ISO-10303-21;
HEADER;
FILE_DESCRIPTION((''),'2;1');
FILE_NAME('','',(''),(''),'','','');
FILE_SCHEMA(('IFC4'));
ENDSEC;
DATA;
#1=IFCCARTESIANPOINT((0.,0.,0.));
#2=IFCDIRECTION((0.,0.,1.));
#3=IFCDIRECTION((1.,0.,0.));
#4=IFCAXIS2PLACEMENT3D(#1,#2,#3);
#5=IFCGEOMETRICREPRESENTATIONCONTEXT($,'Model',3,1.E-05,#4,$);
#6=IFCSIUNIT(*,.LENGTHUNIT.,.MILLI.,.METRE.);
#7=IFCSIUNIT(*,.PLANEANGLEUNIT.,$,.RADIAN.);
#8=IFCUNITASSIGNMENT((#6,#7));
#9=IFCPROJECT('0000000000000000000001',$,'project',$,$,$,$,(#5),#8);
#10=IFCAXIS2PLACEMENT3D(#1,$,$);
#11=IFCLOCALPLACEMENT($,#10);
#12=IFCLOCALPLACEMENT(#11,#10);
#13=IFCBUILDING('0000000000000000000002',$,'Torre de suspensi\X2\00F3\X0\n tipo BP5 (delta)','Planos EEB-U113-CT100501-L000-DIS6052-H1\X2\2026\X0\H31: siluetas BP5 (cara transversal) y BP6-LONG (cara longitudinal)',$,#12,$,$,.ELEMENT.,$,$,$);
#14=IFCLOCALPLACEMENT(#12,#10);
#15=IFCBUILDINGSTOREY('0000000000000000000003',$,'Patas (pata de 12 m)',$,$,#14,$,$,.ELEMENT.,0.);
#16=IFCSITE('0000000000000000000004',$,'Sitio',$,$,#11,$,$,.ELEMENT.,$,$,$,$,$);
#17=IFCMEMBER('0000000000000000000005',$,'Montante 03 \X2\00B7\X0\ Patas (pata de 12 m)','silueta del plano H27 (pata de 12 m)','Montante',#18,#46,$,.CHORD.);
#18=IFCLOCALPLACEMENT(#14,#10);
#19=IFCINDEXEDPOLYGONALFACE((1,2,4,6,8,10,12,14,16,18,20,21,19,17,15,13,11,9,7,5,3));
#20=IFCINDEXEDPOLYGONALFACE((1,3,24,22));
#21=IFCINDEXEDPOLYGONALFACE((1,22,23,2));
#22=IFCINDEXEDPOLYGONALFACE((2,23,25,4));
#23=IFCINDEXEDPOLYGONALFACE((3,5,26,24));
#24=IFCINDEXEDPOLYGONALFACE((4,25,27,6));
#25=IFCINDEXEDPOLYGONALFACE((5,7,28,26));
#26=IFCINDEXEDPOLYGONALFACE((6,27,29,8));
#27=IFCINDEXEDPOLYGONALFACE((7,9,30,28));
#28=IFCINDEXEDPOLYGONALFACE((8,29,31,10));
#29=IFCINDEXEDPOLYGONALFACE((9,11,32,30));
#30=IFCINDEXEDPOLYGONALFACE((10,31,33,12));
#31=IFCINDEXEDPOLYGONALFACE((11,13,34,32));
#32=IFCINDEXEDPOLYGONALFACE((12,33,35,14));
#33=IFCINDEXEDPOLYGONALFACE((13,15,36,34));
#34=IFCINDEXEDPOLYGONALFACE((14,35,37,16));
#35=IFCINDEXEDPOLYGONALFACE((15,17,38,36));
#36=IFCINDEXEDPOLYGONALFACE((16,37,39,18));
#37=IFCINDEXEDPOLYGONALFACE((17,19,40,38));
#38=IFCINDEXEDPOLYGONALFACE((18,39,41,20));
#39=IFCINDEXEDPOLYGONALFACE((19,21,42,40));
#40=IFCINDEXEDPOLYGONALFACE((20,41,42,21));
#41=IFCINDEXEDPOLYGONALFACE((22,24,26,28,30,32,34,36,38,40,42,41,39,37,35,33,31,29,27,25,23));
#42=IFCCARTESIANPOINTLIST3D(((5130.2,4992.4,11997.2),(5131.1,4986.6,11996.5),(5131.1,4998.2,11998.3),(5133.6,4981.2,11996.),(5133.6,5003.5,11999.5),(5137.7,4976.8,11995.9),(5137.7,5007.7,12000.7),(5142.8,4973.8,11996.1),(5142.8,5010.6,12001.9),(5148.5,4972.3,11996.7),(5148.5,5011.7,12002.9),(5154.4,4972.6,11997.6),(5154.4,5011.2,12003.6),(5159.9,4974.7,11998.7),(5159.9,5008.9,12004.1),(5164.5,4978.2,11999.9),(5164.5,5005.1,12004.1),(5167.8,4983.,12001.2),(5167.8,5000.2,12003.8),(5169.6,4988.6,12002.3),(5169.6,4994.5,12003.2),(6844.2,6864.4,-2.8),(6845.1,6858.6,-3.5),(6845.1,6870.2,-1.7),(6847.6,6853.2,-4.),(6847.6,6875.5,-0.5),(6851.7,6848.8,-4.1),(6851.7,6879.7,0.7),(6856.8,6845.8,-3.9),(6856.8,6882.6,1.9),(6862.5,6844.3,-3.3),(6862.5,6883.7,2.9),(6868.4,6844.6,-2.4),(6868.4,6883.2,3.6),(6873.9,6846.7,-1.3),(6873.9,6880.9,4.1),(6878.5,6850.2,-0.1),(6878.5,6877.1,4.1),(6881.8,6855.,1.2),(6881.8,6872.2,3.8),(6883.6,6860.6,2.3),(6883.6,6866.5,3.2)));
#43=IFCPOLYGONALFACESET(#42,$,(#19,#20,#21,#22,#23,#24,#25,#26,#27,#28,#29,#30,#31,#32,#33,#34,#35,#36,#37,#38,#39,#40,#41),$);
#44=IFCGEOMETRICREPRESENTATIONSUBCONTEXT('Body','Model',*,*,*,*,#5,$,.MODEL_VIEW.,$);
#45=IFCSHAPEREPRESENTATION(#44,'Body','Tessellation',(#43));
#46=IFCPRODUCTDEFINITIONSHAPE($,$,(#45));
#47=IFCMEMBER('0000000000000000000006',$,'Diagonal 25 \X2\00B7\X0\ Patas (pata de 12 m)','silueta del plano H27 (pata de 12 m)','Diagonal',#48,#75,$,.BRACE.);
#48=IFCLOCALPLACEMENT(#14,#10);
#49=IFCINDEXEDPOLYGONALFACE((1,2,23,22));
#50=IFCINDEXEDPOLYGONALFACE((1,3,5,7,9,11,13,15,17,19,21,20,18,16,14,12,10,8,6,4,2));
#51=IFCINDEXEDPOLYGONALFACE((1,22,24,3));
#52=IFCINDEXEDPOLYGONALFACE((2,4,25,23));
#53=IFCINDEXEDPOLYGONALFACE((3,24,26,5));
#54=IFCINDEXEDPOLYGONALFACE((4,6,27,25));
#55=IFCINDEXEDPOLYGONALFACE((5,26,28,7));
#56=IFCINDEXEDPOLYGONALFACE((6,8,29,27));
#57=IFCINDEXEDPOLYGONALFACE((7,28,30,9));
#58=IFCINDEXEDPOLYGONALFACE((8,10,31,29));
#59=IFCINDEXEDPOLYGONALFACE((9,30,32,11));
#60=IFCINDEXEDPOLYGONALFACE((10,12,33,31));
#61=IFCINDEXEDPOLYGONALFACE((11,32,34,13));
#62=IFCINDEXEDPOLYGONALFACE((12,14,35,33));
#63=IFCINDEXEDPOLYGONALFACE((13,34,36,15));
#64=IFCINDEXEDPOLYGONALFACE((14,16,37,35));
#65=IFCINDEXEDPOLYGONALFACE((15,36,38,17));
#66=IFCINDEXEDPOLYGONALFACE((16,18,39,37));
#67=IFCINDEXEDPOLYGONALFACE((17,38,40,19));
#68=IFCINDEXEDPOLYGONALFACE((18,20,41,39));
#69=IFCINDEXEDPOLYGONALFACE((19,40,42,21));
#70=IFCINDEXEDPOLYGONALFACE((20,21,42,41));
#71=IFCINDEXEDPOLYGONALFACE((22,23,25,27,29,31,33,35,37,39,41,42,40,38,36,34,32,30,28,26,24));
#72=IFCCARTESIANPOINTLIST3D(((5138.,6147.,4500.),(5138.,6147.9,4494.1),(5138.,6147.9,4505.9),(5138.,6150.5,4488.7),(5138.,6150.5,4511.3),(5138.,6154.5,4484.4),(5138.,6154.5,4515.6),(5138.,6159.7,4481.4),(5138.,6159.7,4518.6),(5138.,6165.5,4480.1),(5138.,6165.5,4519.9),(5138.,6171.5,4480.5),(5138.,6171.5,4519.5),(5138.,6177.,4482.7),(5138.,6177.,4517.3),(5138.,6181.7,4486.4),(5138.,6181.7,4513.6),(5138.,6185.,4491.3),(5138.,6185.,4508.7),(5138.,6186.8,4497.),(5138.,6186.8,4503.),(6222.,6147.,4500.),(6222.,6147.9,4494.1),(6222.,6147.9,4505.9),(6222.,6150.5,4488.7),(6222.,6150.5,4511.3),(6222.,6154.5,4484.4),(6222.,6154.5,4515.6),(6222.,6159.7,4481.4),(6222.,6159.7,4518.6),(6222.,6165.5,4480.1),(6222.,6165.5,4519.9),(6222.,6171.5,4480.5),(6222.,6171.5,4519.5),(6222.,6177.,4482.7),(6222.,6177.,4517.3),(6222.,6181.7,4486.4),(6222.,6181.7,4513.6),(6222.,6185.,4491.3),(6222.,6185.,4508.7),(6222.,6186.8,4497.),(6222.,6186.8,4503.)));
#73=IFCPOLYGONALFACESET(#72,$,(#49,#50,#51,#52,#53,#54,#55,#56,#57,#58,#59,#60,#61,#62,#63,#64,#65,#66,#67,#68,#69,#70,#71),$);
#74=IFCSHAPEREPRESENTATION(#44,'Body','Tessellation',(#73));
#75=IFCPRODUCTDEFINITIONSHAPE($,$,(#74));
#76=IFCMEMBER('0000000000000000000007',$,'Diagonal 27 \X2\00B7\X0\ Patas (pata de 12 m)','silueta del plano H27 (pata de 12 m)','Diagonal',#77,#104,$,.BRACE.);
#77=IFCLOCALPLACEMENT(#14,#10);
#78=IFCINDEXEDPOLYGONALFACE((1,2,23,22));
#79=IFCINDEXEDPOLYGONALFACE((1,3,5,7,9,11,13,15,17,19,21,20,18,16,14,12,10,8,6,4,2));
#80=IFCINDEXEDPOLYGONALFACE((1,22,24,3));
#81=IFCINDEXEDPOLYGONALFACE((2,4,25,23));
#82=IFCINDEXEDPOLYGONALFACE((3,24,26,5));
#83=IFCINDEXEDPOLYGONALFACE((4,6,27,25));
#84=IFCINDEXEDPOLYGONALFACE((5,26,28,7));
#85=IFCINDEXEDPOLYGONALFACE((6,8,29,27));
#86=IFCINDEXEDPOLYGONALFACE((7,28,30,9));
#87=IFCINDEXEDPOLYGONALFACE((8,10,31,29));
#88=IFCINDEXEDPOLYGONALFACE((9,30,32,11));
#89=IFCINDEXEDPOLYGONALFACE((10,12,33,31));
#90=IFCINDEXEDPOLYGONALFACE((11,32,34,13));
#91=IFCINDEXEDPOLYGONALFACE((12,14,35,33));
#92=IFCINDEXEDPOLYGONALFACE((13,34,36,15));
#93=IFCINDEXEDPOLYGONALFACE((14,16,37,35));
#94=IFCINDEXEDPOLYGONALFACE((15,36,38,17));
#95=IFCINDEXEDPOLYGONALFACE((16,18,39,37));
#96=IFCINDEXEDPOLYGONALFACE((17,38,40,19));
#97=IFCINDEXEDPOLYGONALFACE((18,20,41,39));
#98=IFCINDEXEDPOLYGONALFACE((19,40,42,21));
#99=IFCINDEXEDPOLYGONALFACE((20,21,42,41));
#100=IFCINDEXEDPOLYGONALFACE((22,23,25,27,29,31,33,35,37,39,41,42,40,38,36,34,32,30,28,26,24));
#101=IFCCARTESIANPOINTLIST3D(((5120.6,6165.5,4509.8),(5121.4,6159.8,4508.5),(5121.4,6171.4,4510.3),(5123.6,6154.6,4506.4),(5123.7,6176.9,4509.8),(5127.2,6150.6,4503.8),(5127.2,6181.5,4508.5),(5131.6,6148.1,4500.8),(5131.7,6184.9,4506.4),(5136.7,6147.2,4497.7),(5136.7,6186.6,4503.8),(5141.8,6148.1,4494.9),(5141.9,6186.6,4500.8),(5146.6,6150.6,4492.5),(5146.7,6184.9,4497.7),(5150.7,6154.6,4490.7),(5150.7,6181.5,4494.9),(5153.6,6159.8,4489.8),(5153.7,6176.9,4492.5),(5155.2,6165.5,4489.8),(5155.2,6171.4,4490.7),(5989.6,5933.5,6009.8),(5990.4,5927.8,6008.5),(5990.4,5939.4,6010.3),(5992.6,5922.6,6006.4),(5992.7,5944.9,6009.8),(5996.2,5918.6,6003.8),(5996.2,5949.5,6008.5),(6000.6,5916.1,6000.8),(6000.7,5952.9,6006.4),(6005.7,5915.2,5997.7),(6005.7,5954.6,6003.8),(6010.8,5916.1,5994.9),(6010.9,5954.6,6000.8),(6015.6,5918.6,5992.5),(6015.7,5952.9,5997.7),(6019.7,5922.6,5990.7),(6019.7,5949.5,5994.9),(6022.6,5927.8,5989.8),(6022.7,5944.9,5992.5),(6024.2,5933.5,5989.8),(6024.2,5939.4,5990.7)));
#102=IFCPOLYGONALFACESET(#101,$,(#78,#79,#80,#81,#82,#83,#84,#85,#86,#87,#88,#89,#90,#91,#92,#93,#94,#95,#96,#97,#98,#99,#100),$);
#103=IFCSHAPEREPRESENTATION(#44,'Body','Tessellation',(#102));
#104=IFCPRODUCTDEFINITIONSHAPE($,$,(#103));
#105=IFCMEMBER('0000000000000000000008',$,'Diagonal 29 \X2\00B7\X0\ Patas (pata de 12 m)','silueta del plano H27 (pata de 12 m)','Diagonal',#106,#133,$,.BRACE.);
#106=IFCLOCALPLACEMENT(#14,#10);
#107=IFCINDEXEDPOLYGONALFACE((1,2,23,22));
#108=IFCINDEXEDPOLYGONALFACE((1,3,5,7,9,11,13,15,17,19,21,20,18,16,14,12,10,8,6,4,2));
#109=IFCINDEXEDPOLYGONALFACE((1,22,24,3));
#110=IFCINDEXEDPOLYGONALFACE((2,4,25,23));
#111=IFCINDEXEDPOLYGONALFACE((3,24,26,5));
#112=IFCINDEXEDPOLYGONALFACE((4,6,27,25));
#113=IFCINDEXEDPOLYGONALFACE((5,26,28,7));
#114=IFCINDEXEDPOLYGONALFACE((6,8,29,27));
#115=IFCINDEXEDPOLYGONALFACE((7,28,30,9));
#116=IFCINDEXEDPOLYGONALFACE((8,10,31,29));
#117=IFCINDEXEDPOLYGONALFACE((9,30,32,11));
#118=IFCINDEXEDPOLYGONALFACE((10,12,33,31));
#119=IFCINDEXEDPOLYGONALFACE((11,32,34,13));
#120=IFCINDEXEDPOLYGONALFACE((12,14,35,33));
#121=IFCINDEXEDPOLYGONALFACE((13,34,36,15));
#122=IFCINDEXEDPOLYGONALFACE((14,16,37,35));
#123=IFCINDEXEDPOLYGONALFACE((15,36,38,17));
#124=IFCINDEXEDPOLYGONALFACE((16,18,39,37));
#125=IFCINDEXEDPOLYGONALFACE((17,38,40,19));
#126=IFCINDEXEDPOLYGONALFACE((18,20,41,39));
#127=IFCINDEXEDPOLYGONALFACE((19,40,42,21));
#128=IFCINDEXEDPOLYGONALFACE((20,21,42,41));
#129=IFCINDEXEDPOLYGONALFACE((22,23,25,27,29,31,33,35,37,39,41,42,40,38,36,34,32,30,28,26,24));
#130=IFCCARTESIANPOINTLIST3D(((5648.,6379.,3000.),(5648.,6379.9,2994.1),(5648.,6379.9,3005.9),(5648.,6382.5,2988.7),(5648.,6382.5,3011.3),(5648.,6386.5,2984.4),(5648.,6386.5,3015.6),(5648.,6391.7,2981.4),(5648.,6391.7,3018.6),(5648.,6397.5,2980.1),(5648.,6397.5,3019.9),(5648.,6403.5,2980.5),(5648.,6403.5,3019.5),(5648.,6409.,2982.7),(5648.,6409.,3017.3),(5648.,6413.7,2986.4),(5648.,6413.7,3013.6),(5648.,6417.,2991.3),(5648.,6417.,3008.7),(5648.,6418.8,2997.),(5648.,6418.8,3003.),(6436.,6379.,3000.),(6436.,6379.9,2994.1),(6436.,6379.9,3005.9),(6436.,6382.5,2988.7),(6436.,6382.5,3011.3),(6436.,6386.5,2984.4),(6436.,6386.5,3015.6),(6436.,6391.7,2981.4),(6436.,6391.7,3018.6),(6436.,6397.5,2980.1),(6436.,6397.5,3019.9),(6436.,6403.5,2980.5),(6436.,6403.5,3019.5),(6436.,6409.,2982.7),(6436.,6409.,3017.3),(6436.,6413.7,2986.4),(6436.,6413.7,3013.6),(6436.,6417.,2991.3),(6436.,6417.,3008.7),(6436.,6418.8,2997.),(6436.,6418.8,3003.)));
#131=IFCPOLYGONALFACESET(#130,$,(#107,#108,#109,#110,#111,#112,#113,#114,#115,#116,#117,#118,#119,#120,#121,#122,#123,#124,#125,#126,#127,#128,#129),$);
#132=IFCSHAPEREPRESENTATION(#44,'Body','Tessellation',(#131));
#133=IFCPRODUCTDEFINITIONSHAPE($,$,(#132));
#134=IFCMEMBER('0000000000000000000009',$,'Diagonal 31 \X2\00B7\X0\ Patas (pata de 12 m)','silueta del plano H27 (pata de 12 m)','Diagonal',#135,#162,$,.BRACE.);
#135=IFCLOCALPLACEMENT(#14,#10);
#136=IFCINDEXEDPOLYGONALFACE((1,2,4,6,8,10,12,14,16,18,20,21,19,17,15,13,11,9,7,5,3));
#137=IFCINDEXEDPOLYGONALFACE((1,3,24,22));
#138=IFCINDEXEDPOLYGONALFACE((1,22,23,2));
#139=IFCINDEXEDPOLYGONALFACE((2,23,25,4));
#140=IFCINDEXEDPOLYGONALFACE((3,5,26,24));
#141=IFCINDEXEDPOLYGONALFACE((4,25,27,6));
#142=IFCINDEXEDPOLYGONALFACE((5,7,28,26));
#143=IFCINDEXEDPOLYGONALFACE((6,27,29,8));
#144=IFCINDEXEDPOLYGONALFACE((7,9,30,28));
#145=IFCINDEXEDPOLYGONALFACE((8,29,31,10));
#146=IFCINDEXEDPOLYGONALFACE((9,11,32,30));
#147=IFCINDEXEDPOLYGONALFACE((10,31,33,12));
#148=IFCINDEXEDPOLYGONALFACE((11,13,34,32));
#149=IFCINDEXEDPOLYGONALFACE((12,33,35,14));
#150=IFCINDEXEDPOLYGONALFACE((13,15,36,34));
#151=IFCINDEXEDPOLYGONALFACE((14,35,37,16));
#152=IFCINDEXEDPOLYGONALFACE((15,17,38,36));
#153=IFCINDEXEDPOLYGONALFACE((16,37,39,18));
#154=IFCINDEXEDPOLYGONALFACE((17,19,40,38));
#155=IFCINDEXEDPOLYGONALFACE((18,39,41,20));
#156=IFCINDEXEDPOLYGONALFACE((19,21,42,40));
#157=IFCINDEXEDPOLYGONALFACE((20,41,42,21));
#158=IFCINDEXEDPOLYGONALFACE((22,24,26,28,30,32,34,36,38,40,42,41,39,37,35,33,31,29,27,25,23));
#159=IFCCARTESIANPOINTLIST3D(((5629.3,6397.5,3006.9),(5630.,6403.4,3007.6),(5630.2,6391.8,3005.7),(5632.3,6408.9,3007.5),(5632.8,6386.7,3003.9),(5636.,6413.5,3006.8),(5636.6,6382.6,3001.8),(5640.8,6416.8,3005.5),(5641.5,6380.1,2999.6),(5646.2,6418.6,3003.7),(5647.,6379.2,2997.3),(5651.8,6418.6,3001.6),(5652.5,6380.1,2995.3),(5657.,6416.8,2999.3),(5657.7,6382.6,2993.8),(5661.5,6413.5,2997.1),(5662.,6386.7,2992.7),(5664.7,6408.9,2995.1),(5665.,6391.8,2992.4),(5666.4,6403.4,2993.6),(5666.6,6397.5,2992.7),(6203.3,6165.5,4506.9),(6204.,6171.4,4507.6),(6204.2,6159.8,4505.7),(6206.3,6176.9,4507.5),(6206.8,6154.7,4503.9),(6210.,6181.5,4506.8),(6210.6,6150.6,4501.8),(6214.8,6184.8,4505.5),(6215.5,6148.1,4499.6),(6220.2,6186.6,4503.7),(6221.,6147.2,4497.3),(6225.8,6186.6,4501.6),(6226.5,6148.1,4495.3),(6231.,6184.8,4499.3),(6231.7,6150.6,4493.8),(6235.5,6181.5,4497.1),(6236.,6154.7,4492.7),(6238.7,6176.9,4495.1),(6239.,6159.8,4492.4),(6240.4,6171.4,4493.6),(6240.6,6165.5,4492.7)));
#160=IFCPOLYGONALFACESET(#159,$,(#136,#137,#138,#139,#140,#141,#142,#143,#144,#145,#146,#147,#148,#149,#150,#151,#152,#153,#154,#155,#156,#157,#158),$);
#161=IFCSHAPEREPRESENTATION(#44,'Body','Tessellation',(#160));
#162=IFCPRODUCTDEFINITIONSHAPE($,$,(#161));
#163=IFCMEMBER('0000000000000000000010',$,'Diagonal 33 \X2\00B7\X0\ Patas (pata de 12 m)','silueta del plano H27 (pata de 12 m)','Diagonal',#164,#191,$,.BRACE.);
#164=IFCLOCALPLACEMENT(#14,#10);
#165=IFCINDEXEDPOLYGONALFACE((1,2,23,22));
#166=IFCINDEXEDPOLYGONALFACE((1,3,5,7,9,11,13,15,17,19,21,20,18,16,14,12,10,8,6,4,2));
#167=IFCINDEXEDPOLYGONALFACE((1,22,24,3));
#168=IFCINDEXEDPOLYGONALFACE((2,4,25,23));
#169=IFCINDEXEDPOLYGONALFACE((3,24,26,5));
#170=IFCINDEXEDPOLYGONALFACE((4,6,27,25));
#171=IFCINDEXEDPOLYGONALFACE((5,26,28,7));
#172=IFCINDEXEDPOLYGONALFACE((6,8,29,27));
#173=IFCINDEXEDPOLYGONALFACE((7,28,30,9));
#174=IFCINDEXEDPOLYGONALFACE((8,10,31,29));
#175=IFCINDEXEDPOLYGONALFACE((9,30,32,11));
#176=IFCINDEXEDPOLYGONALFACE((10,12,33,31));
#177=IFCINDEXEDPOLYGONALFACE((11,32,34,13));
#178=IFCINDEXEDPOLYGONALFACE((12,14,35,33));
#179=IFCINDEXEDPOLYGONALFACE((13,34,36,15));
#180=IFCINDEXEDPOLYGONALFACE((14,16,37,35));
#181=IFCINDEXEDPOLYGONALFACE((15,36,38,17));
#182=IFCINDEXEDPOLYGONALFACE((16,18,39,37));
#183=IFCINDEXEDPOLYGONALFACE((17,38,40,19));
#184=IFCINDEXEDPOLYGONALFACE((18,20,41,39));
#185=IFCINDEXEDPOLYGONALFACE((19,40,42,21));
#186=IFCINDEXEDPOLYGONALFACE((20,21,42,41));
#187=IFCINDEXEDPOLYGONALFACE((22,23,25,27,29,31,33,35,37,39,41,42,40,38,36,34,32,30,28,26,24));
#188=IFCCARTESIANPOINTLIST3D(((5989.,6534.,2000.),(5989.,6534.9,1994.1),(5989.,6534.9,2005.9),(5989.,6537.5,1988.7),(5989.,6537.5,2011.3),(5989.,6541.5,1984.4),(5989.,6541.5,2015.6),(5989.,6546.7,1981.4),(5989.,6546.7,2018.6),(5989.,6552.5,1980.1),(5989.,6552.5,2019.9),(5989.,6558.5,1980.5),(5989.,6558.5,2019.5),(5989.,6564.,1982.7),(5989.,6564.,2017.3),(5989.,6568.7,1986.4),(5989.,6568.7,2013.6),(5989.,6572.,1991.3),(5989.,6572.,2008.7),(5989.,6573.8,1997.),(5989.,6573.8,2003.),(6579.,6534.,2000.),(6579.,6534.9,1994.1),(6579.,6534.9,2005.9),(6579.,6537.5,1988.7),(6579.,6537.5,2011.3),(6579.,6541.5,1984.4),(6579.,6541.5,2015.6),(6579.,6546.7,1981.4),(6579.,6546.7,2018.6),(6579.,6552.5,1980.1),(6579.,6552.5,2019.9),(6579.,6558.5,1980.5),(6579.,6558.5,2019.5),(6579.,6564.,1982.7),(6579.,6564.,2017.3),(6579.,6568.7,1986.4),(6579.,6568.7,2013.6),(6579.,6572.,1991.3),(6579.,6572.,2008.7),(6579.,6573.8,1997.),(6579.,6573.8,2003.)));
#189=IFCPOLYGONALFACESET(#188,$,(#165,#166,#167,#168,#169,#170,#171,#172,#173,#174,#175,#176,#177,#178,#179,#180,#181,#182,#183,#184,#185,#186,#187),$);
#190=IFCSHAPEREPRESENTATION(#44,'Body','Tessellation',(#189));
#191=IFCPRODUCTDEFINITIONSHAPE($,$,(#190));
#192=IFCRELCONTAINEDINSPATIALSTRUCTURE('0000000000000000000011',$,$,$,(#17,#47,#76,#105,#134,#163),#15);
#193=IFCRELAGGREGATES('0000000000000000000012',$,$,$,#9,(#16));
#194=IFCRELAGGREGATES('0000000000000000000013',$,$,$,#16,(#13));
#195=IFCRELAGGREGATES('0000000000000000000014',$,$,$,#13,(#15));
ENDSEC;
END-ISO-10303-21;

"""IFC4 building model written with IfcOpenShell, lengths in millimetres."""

from ifc_helpers import new_model, si_unit, frame, origin, origin_with_axes, place, context, subcontext, project, spatial, circle, extrude, element, save


model = new_model("IFC4")

# Units and contexts
model_context = context("Model", 3, precision=1e-05, world=origin_with_axes())
body_context = subcontext(model_context, "Body", "Model", "MODEL_VIEW")
ifc_project = project(units=[si_unit("LENGTHUNIT", "METRE", prefix="MILLI"), si_unit("PLANEANGLEUNIT", "RADIAN")], contexts=[model_context])

# Site, building, storey
site_placement = place(None, origin())
site = spatial("IfcSite", under=ifc_project, at=site_placement, Name="Sitio", CompositionType="ELEMENT")
building_placement = place(site_placement, origin())
building = spatial("IfcBuilding", under=site, at=building_placement, Name="Torre de suspensión tipo BP5 (delta)", Description="Planos EEB-U113-CT100501-L000-DIS6052-H1…H31: siluetas BP5 (cara transversal) y BP6-LONG (cara longitudinal)", CompositionType="ELEMENT")
storey_placement = place(building_placement, origin())
storey = spatial("IfcBuildingStorey", under=building, at=storey_placement, Name="Patas (pata de 12 m)", CompositionType="ELEMENT", Elevation=0.0)

# Members
member_1_placement = place(storey_placement, frame((6864.0, 6864.0, 0.0), z_axis=(-0.139742, -0.152623, 0.978355), x_axis=(-0.990188, 0.021539, -0.138072)))
element("IfcMember", 1, at=member_1_placement, inside=storey, Name="Montante 03 · Patas (pata de 12 m)", Description="silueta del plano H27 (pata de 12 m)", ObjectType="Montante", PredefinedType="CHORD", context=body_context, shape_type="SweptSolid", body=[
    extrude(circle(Radius=20.0), None, (0.0, 0.0, 1.0), 12265.5),
])
member_2_placement = place(storey_placement, frame((6222.0, 6167.0, 4500.0), z_axis=(-1.0, 0.0, 0.0), x_axis=(0.0, -1.0, 0.0)))
element("IfcMember", 2, at=member_2_placement, inside=storey, Name="Diagonal 25 · Patas (pata de 12 m)", Description="silueta del plano H27 (pata de 12 m)", ObjectType="Diagonal", PredefinedType="BRACE", context=body_context, shape_type="SweptSolid", body=[
    extrude(circle(Radius=20.0), None, (0.0, 0.0, 1.0), 1084.0),
])
member_3_placement = place(storey_placement, frame((5138.0, 6167.0, 4500.0), z_axis=(0.496857, -0.132648, 0.857635), x_axis=(-0.066494, -0.991163, -0.114777)))
element("IfcMember", 3, at=member_3_placement, inside=storey, Name="Diagonal 27 · Patas (pata de 12 m)", Description="silueta del plano H27 (pata de 12 m)", ObjectType="Diagonal", PredefinedType="BRACE", context=body_context, shape_type="SweptSolid", body=[
    extrude(circle(Radius=20.0), None, (0.0, 0.0, 1.0), 1749.0),
])
member_4_placement = place(storey_placement, frame((6436.0, 6399.0, 3000.0), z_axis=(-1.0, 0.0, 0.0), x_axis=(0.0, -1.0, 0.0)))
element("IfcMember", 4, at=member_4_placement, inside=storey, Name="Diagonal 29 · Patas (pata de 12 m)", Description="silueta del plano H27 (pata de 12 m)", ObjectType="Diagonal", PredefinedType="BRACE", context=body_context, shape_type="SweptSolid", body=[
    extrude(circle(Radius=20.0), None, (0.0, 0.0, 1.0), 788.0),
])
member_5_placement = place(storey_placement, frame((5648.0, 6399.0, 3000.0), z_axis=(0.353722, -0.142968, 0.92436), x_axis=(-0.051096, -0.989727, -0.133525)))
element("IfcMember", 5, at=member_5_placement, inside=storey, Name="Diagonal 31 · Patas (pata de 12 m)", Description="silueta del plano H27 (pata de 12 m)", ObjectType="Diagonal", PredefinedType="BRACE", context=body_context, shape_type="SweptSolid", body=[
    extrude(circle(Radius=20.0), None, (0.0, 0.0, 1.0), 1622.7),
])
member_6_placement = place(storey_placement, frame((6579.0, 6554.0, 2000.0), z_axis=(-1.0, 0.0, 0.0), x_axis=(0.0, -1.0, 0.0)))
element("IfcMember", 6, at=member_6_placement, inside=storey, Name="Diagonal 33 · Patas (pata de 12 m)", Description="silueta del plano H27 (pata de 12 m)", ObjectType="Diagonal", PredefinedType="BRACE", context=body_context, shape_type="SweptSolid", body=[
    extrude(circle(Radius=20.0), None, (0.0, 0.0, 1.0), 590.0),
])

save(model, "model.ifc")
